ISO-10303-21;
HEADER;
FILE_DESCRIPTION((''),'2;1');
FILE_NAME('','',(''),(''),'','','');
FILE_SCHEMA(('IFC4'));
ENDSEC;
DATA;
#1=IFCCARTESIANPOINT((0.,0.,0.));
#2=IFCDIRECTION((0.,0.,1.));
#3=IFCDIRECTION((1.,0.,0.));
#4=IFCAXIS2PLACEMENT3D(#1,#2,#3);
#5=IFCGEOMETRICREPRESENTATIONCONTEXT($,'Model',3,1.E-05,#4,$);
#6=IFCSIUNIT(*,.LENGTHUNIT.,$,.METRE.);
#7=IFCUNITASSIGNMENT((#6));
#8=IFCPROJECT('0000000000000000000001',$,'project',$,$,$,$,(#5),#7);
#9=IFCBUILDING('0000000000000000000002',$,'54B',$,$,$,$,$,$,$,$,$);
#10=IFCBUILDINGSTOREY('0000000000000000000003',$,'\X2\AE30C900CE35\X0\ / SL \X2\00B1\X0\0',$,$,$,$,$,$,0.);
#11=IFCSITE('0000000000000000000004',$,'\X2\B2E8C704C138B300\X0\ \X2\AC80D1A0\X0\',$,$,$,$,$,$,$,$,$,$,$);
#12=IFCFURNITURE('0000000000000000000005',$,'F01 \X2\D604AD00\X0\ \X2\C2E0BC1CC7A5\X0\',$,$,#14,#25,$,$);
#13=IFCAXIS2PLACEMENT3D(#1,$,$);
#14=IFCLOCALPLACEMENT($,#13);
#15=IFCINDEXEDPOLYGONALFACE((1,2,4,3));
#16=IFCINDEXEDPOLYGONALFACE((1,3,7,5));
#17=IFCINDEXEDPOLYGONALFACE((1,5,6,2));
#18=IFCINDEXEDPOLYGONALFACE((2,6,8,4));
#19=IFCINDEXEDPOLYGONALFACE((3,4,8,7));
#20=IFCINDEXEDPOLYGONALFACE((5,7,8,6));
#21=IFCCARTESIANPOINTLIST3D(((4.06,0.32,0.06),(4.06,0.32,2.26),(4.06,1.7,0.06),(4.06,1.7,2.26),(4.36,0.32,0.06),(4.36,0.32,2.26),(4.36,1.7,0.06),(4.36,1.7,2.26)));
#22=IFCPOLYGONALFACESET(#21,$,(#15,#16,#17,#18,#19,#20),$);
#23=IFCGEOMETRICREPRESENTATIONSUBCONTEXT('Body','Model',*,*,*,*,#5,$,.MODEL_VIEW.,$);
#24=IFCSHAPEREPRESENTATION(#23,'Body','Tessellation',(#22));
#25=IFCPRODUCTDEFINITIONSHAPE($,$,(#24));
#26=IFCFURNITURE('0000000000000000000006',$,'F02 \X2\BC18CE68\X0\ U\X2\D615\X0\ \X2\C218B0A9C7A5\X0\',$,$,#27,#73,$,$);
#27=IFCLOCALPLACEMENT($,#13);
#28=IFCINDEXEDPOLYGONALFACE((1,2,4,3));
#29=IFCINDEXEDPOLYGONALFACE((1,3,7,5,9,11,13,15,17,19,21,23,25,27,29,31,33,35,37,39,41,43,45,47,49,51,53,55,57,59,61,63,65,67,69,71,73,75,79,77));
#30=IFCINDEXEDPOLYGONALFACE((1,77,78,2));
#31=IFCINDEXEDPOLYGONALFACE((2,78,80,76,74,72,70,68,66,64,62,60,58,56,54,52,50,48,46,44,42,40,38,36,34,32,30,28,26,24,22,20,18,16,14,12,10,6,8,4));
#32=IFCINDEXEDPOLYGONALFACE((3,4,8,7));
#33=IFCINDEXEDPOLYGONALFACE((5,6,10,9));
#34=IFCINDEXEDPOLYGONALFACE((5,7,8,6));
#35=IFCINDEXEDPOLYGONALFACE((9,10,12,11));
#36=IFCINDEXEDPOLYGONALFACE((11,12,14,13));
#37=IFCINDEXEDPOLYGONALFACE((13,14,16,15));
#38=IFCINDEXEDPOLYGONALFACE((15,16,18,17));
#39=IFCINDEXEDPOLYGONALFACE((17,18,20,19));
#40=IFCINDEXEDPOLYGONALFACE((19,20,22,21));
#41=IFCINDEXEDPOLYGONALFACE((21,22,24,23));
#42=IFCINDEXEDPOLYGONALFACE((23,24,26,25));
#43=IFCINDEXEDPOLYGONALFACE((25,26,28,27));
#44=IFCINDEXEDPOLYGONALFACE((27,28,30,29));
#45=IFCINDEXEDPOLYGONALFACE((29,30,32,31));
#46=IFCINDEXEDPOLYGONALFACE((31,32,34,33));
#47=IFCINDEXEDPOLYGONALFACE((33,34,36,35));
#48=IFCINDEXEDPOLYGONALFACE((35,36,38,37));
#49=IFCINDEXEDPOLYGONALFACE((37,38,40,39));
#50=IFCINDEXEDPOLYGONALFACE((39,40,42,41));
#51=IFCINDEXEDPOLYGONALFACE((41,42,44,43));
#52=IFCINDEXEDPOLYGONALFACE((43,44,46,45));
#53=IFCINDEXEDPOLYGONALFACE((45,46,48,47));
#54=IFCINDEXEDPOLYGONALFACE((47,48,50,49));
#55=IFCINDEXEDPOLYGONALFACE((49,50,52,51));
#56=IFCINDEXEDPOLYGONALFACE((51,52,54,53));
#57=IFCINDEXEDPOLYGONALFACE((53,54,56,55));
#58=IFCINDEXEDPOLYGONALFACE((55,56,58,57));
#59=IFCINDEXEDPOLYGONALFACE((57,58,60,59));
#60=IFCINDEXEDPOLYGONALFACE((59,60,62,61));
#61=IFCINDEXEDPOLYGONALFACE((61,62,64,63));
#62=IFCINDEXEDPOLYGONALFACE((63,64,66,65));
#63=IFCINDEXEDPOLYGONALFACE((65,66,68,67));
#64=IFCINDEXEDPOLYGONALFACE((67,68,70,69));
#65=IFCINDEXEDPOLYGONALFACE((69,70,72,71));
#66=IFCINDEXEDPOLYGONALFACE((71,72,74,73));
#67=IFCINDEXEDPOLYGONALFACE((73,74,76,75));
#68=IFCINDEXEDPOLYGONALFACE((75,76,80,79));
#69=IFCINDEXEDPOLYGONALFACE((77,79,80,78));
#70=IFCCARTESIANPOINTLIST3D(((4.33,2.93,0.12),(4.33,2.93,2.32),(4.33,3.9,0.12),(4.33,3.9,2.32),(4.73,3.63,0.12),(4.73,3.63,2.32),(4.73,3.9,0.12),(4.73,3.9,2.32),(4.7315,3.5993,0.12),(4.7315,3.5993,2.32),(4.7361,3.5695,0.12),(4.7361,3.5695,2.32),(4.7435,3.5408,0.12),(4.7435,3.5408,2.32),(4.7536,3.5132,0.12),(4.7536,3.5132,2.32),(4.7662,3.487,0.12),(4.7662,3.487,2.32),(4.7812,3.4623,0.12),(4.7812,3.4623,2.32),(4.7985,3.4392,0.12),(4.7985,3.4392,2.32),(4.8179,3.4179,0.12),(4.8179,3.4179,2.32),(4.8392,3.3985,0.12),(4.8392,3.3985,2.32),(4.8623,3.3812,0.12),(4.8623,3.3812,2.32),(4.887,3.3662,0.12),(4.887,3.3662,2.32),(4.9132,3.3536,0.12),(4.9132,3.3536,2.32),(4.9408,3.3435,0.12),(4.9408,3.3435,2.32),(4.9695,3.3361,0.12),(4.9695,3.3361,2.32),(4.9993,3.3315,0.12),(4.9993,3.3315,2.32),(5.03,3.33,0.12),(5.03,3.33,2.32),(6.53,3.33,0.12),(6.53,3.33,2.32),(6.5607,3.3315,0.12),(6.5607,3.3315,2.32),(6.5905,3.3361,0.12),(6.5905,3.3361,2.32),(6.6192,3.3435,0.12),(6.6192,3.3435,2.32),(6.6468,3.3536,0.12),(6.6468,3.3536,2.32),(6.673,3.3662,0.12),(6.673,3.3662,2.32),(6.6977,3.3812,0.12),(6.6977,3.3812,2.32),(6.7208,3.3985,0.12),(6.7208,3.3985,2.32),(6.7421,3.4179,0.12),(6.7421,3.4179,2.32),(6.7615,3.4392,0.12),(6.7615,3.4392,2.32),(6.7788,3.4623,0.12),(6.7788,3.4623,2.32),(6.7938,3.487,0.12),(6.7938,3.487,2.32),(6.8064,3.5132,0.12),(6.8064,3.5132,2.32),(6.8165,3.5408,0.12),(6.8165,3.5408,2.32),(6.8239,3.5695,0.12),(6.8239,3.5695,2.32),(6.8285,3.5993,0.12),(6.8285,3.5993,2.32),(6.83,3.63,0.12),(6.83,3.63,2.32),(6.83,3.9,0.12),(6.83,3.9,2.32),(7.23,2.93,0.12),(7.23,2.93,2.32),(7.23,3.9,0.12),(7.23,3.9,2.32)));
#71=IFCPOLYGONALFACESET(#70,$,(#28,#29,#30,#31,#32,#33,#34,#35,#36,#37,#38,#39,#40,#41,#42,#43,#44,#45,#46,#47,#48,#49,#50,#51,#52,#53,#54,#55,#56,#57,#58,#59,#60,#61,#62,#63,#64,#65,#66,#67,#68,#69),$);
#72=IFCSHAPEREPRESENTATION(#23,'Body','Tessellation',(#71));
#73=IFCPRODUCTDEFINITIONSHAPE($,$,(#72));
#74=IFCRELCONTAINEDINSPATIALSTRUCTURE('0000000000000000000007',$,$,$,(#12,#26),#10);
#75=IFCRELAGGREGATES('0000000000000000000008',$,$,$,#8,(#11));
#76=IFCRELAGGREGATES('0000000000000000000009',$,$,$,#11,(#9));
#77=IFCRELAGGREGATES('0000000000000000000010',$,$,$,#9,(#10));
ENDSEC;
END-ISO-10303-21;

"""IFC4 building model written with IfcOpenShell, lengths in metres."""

from ifc_helpers import new_model, si_unit, frame, origin_with_axes, place, context, subcontext, project, spatial, polyline, outline, extrude, element, save


model = new_model("IFC4")

# Units and contexts
model_context = context("Model", 3, precision=1e-05, world=origin_with_axes())
body_context = subcontext(model_context, "Body", "Model", "MODEL_VIEW")
ifc_project = project(units=[si_unit("LENGTHUNIT", "METRE")], contexts=[model_context])

# Site, building, storey
site = spatial("IfcSite", under=ifc_project, Name="단위세대 검토")
building = spatial("IfcBuilding", under=site, Name="54B")
storey = spatial("IfcBuildingStorey", under=building, Name="기준층 / SL ±0", Elevation=0.0)

# Furniture
furniture_1_placement = place(None, origin_with_axes())
element("IfcFurniture", 1, at=furniture_1_placement, inside=storey, Name="F01 현관 신발장", context=body_context, shape_type="SweptSolid", body=[
    extrude(outline(polyline([(4.06, 0.32), (4.36, 0.32), (4.36, 1.7), (4.06, 1.7), (4.06, 0.32)])), frame((0.0, 0.0, 0.06)), (0.0, 0.0, 1.0), 2.2),
])
furniture_2_placement = place(None, origin_with_axes())
element("IfcFurniture", 2, at=furniture_2_placement, inside=storey, Name="F02 반침 U형 수납장", context=body_context, shape_type="SweptSolid", body=[
    extrude(outline(polyline([(4.33, 3.9), (4.33, 2.93), (7.23, 2.93), (7.23, 3.9), (6.83, 3.9), (6.83, 3.63), (6.8285, 3.5993), (6.8239, 3.5695), (6.8165, 3.5408), (6.8064, 3.5132), (6.7938, 3.487), (6.7788, 3.4623), (6.7615, 3.4392), (6.7421, 3.4179), (6.7208, 3.3985), (6.6977, 3.3812), (6.673, 3.3662), (6.6468, 3.3536), (6.6192, 3.3435), (6.5905, 3.3361), (6.5607, 3.3315), (6.53, 3.33), (5.03, 3.33), (4.9993, 3.3315), (4.9695, 3.3361), (4.9408, 3.3435), (4.9132, 3.3536), (4.887, 3.3662), (4.8623, 3.3812), (4.8392, 3.3985), (4.8179, 3.4179), (4.7985, 3.4392), (4.7812, 3.4623), (4.7662, 3.487), (4.7536, 3.5132), (4.7435, 3.5408), (4.7361, 3.5695), (4.7315, 3.5993), (4.73, 3.63), (4.73, 3.9), (4.33, 3.9)])), frame((0.0, 0.0, 0.12)), (0.0, 0.0, 1.0), 2.2),
])

save(model, "model.ifc")
